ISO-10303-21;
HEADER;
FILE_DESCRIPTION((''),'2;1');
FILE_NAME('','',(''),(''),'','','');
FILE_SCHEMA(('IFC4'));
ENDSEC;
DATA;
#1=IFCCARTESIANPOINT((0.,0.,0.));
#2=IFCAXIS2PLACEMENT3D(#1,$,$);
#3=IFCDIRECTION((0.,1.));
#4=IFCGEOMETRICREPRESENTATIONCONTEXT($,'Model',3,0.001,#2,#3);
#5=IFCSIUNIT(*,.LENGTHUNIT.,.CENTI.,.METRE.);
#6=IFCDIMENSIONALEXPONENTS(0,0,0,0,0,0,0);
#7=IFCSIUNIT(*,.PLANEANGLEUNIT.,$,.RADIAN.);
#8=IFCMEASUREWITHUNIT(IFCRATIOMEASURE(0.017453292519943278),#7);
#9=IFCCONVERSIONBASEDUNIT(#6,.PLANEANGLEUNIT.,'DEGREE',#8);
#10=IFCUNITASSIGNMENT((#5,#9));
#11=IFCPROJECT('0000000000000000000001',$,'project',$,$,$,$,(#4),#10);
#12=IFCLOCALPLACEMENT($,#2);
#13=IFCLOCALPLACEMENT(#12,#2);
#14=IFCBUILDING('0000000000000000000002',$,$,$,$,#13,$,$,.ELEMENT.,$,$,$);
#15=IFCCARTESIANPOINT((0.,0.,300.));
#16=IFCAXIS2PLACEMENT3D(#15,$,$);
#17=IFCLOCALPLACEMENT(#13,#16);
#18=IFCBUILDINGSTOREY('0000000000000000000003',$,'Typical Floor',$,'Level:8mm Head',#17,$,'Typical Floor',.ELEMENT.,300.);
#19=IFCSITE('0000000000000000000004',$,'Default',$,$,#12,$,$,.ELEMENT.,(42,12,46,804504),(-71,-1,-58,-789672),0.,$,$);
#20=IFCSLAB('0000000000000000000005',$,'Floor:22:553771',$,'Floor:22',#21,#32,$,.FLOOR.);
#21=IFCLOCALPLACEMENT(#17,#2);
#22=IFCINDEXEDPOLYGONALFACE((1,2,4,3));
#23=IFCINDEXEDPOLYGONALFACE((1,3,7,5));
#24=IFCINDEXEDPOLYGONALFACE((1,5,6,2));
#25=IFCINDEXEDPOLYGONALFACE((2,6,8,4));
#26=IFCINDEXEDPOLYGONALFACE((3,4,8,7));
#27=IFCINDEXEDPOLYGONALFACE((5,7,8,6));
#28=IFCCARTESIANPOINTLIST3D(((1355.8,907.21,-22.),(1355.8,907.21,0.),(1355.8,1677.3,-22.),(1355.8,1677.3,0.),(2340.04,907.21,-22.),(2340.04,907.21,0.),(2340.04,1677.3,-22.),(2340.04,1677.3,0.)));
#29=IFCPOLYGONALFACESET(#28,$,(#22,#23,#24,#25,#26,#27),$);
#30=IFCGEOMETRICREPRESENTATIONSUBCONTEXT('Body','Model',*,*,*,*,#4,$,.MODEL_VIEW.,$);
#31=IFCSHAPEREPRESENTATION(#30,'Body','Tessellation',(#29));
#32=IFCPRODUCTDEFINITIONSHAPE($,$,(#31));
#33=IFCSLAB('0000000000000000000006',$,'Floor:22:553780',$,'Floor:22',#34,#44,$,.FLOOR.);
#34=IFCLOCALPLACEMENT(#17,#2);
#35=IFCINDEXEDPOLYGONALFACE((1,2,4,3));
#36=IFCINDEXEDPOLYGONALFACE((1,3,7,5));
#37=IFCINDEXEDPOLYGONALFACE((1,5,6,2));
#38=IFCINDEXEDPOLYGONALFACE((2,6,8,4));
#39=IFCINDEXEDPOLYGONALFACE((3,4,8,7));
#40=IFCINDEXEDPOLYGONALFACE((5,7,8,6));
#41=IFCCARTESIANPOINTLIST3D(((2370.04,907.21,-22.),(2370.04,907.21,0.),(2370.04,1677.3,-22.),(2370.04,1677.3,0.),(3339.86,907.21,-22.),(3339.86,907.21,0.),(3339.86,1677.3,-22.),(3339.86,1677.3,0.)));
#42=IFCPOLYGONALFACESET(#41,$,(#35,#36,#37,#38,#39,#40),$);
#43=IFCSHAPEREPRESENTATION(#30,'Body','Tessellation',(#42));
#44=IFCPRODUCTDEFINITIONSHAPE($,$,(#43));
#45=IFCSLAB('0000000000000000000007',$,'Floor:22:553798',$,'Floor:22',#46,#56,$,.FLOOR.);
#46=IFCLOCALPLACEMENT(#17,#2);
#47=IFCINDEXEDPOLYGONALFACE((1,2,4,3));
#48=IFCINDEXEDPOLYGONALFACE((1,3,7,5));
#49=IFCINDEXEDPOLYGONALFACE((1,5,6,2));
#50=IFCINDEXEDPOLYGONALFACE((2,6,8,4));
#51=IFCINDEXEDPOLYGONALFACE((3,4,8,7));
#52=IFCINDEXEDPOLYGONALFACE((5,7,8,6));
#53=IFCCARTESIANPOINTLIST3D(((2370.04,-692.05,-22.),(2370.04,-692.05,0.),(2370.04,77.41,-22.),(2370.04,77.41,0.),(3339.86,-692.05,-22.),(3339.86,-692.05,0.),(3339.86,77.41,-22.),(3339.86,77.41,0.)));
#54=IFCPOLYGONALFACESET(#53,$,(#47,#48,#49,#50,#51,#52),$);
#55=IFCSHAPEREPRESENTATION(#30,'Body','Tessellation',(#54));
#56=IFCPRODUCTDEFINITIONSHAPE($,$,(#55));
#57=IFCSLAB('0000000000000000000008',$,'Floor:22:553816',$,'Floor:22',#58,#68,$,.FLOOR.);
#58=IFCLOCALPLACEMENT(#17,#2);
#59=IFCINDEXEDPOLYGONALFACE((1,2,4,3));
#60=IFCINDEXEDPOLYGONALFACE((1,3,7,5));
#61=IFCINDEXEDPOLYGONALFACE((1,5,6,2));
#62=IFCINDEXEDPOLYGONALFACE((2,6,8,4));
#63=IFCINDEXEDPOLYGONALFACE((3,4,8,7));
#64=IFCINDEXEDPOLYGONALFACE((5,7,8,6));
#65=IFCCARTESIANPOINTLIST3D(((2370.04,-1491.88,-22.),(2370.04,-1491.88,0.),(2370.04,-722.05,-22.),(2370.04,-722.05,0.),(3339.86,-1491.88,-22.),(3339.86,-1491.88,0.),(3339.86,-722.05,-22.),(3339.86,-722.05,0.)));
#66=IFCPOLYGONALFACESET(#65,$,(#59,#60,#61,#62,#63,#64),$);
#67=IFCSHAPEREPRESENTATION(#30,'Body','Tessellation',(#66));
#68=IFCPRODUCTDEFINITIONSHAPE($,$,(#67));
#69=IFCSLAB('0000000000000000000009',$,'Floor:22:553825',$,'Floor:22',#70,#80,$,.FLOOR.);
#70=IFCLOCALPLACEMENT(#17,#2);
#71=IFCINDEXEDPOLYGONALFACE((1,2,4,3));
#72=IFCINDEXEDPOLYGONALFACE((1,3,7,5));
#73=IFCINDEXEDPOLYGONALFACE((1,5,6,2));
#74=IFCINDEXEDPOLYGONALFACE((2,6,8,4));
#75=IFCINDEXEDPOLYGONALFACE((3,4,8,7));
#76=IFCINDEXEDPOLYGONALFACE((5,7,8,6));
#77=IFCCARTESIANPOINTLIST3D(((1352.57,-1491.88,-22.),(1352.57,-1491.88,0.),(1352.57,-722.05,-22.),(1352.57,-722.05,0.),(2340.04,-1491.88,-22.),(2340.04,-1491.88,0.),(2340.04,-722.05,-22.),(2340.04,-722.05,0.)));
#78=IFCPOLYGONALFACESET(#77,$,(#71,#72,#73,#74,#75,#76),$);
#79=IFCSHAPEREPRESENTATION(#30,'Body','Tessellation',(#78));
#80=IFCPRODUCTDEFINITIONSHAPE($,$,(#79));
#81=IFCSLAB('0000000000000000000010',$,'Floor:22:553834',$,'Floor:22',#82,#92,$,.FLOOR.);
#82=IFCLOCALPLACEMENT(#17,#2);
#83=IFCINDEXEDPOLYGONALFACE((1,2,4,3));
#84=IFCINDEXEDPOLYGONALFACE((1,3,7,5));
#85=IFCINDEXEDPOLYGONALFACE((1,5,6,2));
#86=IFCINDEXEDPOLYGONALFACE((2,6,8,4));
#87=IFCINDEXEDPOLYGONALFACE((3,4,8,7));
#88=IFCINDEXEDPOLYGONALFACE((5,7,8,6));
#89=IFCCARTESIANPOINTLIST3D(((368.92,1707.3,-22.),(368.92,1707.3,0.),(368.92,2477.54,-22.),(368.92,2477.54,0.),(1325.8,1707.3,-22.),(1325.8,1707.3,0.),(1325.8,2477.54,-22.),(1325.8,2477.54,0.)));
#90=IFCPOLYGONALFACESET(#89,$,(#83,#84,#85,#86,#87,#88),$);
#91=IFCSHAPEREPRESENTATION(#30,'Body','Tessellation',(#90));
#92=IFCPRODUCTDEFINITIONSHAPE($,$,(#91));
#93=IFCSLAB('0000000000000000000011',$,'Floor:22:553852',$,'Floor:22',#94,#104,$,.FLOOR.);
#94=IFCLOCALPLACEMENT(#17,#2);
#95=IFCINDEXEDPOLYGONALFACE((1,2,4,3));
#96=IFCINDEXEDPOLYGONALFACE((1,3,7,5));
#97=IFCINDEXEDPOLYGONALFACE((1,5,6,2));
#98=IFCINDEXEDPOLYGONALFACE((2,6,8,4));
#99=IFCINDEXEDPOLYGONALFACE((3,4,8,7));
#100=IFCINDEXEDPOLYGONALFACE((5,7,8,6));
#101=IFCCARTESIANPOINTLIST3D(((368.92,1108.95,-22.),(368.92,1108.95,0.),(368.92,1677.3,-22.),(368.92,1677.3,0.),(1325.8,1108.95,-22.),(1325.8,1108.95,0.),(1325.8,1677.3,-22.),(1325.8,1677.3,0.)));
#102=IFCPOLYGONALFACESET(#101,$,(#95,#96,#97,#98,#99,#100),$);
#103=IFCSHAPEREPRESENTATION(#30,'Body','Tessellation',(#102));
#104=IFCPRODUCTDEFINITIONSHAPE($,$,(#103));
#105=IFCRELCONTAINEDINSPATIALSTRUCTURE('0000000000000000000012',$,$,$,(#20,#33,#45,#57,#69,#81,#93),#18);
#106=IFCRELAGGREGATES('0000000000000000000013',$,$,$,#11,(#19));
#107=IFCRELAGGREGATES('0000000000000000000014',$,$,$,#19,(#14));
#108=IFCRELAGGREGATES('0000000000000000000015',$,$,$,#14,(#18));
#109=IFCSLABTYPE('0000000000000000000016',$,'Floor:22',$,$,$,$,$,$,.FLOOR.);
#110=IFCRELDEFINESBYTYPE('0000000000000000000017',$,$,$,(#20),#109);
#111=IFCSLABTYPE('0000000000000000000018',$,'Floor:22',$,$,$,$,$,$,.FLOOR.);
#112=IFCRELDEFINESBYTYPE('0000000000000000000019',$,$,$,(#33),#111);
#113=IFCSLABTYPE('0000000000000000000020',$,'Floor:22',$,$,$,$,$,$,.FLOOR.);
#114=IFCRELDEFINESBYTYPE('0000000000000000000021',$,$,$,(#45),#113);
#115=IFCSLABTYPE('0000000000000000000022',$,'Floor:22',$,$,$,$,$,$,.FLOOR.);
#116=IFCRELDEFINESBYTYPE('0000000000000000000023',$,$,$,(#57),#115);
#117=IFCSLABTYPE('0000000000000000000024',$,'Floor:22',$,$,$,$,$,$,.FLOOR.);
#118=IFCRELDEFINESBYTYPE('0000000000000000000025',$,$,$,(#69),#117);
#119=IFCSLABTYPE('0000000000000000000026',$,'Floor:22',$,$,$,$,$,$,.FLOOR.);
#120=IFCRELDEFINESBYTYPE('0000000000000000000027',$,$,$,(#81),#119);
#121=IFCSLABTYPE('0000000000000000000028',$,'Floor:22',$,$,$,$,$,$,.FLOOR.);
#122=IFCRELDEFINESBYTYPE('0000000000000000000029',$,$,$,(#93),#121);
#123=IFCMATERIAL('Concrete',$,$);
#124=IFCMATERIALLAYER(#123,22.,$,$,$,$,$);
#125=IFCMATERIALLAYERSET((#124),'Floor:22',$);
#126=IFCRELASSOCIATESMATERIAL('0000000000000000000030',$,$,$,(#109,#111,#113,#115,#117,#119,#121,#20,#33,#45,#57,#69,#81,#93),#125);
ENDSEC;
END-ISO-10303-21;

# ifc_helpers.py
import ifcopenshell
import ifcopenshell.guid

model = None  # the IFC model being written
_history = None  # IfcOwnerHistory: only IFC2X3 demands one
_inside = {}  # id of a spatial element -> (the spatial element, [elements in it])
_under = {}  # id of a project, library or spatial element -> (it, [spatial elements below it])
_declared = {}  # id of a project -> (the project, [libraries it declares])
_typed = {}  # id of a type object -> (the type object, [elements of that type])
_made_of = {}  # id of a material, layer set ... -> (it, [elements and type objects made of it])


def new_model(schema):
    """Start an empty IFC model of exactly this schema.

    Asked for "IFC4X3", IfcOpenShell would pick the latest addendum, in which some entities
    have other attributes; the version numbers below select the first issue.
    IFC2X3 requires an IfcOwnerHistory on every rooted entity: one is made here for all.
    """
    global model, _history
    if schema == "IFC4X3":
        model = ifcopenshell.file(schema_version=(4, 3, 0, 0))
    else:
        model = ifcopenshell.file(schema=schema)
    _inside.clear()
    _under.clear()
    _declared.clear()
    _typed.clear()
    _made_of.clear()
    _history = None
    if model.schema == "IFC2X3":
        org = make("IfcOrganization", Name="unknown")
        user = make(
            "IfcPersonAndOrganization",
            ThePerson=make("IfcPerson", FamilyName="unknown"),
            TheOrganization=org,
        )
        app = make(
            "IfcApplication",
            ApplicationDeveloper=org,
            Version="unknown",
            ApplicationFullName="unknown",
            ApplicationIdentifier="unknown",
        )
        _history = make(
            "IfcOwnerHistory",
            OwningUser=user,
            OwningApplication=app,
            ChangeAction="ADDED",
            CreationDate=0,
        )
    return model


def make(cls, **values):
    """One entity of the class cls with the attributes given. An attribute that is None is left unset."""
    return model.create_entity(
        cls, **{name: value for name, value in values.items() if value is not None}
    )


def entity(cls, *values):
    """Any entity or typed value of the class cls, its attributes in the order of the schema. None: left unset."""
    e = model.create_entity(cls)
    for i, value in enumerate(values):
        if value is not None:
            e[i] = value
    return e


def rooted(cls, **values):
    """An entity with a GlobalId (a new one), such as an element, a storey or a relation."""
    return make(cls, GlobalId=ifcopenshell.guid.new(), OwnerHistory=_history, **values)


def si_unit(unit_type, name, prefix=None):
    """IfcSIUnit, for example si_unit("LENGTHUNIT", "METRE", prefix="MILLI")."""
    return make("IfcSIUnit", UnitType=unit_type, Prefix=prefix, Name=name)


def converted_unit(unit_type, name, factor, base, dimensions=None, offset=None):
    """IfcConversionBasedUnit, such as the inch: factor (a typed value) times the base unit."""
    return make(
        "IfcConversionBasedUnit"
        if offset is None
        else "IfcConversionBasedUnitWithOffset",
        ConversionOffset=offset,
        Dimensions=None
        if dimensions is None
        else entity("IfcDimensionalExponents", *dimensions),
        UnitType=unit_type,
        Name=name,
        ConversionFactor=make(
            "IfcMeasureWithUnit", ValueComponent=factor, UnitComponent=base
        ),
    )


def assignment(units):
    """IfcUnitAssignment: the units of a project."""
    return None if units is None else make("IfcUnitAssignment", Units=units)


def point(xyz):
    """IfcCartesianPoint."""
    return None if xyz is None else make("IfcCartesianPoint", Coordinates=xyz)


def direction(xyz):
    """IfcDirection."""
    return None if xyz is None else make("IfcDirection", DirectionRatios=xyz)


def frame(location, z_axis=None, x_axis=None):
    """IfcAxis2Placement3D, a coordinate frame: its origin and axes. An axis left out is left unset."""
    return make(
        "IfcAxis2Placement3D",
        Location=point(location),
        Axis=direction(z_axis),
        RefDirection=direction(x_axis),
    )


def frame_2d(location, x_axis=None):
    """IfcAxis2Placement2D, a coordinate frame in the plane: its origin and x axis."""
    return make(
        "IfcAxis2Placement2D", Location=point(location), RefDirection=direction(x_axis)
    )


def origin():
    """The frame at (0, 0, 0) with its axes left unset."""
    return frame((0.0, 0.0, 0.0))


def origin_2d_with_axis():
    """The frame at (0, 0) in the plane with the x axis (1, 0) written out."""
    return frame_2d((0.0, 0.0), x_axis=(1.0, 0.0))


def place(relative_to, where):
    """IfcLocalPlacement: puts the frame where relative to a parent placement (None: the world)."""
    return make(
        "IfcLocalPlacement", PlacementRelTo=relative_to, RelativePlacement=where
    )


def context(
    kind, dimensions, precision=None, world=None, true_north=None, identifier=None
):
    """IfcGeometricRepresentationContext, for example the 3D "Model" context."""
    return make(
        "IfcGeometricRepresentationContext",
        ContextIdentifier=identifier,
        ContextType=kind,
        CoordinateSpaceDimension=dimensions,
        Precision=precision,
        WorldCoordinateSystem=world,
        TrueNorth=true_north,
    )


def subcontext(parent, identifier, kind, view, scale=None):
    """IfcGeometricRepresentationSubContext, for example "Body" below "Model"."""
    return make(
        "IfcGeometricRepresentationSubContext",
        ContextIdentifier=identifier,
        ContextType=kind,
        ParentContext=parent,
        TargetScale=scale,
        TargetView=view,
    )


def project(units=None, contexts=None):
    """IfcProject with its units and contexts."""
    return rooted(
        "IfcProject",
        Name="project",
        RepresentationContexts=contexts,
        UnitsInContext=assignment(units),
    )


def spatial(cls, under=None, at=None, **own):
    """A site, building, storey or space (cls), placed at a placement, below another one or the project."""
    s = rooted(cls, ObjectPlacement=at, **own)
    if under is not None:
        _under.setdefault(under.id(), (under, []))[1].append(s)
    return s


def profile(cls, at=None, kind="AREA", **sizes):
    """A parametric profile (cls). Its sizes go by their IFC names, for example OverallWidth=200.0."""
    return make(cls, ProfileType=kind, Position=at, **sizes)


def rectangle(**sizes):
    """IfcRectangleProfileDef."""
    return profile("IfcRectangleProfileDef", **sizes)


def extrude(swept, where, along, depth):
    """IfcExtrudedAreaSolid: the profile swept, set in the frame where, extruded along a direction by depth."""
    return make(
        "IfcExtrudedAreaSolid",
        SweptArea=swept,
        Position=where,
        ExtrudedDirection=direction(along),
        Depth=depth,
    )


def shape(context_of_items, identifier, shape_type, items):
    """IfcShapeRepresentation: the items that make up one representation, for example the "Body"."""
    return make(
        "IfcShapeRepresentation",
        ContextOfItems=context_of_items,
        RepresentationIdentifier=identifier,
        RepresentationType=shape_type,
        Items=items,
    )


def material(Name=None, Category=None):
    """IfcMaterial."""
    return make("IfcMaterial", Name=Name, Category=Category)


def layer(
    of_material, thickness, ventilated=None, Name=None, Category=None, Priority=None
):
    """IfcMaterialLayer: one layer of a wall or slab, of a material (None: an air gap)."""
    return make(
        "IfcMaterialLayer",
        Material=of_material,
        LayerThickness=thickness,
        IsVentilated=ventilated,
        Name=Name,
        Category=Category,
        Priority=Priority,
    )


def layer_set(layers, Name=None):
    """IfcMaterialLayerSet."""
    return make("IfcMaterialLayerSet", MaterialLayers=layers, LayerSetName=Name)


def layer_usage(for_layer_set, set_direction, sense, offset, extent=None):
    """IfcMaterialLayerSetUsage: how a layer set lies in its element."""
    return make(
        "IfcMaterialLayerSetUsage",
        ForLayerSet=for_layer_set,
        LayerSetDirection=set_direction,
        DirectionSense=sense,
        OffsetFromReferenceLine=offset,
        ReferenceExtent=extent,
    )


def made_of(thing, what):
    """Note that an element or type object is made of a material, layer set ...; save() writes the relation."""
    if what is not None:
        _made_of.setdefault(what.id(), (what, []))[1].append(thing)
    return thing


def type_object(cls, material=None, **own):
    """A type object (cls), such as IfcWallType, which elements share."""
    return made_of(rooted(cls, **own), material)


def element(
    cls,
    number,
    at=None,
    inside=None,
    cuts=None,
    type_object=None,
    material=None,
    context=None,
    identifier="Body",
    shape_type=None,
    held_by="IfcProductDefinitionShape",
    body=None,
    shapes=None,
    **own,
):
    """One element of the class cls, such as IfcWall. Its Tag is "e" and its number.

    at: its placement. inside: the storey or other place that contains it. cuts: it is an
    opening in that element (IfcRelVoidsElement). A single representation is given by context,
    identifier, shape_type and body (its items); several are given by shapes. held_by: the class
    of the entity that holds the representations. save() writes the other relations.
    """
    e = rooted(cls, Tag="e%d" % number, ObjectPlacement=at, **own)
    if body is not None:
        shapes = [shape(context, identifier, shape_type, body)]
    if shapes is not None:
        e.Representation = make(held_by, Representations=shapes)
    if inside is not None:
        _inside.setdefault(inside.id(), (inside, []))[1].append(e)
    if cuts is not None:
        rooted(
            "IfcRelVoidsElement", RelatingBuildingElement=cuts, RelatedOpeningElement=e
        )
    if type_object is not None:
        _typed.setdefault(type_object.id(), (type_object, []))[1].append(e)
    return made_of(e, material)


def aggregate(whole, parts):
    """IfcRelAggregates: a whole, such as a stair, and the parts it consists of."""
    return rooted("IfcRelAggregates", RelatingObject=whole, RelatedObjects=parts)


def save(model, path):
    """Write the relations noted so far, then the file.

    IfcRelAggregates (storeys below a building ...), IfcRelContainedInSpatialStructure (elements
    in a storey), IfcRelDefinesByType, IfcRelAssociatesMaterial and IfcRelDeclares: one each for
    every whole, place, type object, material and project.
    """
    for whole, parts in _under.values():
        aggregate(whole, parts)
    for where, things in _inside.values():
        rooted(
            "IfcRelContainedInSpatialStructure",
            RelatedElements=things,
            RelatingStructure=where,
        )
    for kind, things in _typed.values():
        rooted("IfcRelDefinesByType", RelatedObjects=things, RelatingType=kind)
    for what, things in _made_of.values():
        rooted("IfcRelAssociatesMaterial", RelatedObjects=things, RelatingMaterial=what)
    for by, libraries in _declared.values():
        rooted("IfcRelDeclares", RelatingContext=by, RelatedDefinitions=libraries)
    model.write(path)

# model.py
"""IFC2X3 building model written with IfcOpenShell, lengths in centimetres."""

from ifc_helpers import new_model, entity, si_unit, converted_unit, direction, frame, frame_2d, origin, origin_2d_with_axis, place, context, subcontext, project, spatial, rectangle, extrude, material, layer, layer_set, layer_usage, type_object, element, save


model = new_model("IFC2X3")

# Units and contexts
model_context = context("Model", 3, precision=0.001, world=origin(), true_north=direction((0.0, 1.0)))
body_context = subcontext(model_context, "Body", "Model", "MODEL_VIEW")
ifc_project = project(units=[si_unit("LENGTHUNIT", "METRE", prefix="CENTI"), converted_unit("PLANEANGLEUNIT", "DEGREE", entity("IfcRatioMeasure", 0.017453292519943278), si_unit("PLANEANGLEUNIT", "RADIAN"), dimensions=[0, 0, 0, 0, 0, 0, 0])], contexts=[model_context])

# Site, building, storey
site_placement = place(None, origin())
site = spatial("IfcSite", under=ifc_project, at=site_placement, Name="Default", CompositionType="ELEMENT", RefLatitude=(42, 12, 46, 804504), RefLongitude=(-71, -1, -58, -789672), RefElevation=0.0)
building_placement = place(site_placement, origin())
building = spatial("IfcBuilding", under=site, at=building_placement, CompositionType="ELEMENT")
storey_placement = place(building_placement, frame((0.0, 0.0, 300.0)))
storey = spatial("IfcBuildingStorey", under=building, at=storey_placement, Name="Typical Floor", ObjectType="Level:8mm Head", LongName="Typical Floor", CompositionType="ELEMENT", Elevation=300.0)

# Shared definitions
ifc_material = material(Name="Concrete")

# Slabs
ifc_layer = layer(ifc_material, 22.0)
ifc_layer_set = layer_set([ifc_layer], Name="Floor:22")
ifc_layer_usage_1 = layer_usage(ifc_layer_set, "AXIS3", "POSITIVE", 0.0)
slab_type_1 = type_object("IfcSlabType", Name="Floor:22", PredefinedType="FLOOR", material=ifc_layer_set)
slab_1_placement = place(storey_placement, origin())
element("IfcSlab", 1, at=slab_1_placement, inside=storey, type_object=slab_type_1, material=ifc_layer_usage_1, Name="Floor:22:553771", ObjectType="Floor:22", PredefinedType="FLOOR", context=body_context, shape_type="SweptSolid", body=[
    extrude(rectangle(XDim=770.09, YDim=984.24, at=origin_2d_with_axis()), frame((1847.92, 1292.26, 0.0), z_axis=(0.0, 0.0, -1.0), x_axis=(0.0, 1.0, 0.0)), (0.0, 0.0, 1.0), 22.0),
])
ifc_layer_usage_2 = layer_usage(ifc_layer_set, "AXIS3", "POSITIVE", 0.0)
slab_type_2 = type_object("IfcSlabType", Name="Floor:22", PredefinedType="FLOOR", material=ifc_layer_set)
slab_2_placement = place(storey_placement, origin())
element("IfcSlab", 2, at=slab_2_placement, inside=storey, type_object=slab_type_2, material=ifc_layer_usage_2, Name="Floor:22:553780", ObjectType="Floor:22", PredefinedType="FLOOR", context=body_context, shape_type="SweptSolid", body=[
    extrude(rectangle(XDim=770.09, YDim=969.83, at=frame_2d((0.0, 0.0), x_axis=(1.0, 0.0))), frame((2854.95, 1292.26, 0.0), z_axis=(0.0, 0.0, -1.0), x_axis=(0.0, 1.0, 0.0)), (0.0, 0.0, 1.0), 22.0),
])
ifc_layer_usage_3 = layer_usage(ifc_layer_set, "AXIS3", "POSITIVE", 0.0)
slab_type_3 = type_object("IfcSlabType", Name="Floor:22", PredefinedType="FLOOR", material=ifc_layer_set)
slab_3_placement = place(storey_placement, origin())
element("IfcSlab", 3, at=slab_3_placement, inside=storey, type_object=slab_type_3, material=ifc_layer_usage_3, Name="Floor:22:553798", ObjectType="Floor:22", PredefinedType="FLOOR", context=body_context, shape_type="SweptSolid", body=[
    extrude(rectangle(XDim=769.46, YDim=969.83, at=frame_2d((0.0, 0.0), x_axis=(1.0, 0.0))), frame((2854.95, -307.32, 0.0), z_axis=(0.0, 0.0, -1.0), x_axis=(0.0, 1.0, 0.0)), (0.0, 0.0, 1.0), 22.0),
])
ifc_layer_usage_4 = layer_usage(ifc_layer_set, "AXIS3", "POSITIVE", 0.0)
slab_type_4 = type_object("IfcSlabType", Name="Floor:22", PredefinedType="FLOOR", material=ifc_layer_set)
slab_4_placement = place(storey_placement, origin())
element("IfcSlab", 4, at=slab_4_placement, inside=storey, type_object=slab_type_4, material=ifc_layer_usage_4, Name="Floor:22:553816", ObjectType="Floor:22", PredefinedType="FLOOR", context=body_context, shape_type="SweptSolid", body=[
    extrude(rectangle(XDim=769.83, YDim=969.83, at=frame_2d((0.0, 0.0), x_axis=(1.0, 0.0))), frame((2854.95, -1106.96, 0.0), z_axis=(0.0, 0.0, -1.0), x_axis=(0.0, 1.0, 0.0)), (0.0, 0.0, 1.0), 22.0),
])
ifc_layer_usage_5 = layer_usage(ifc_layer_set, "AXIS3", "POSITIVE", 0.0)
slab_type_5 = type_object("IfcSlabType", Name="Floor:22", PredefinedType="FLOOR", material=ifc_layer_set)
slab_5_placement = place(storey_placement, origin())
element("IfcSlab", 5, at=slab_5_placement, inside=storey, type_object=slab_type_5, material=ifc_layer_usage_5, Name="Floor:22:553825", ObjectType="Floor:22", PredefinedType="FLOOR", context=body_context, shape_type="SweptSolid", body=[
    extrude(rectangle(XDim=769.83, YDim=987.46, at=frame_2d((0.0, 0.0), x_axis=(1.0, 0.0))), frame((1846.3, -1106.96, 0.0), z_axis=(0.0, 0.0, -1.0), x_axis=(0.0, 1.0, 0.0)), (0.0, 0.0, 1.0), 22.0),
])
ifc_layer_usage_6 = layer_usage(ifc_layer_set, "AXIS3", "POSITIVE", 0.0)
slab_type_6 = type_object("IfcSlabType", Name="Floor:22", PredefinedType="FLOOR", material=ifc_layer_set)
slab_6_placement = place(storey_placement, origin())
element("IfcSlab", 6, at=slab_6_placement, inside=storey, type_object=slab_type_6, material=ifc_layer_usage_6, Name="Floor:22:553834", ObjectType="Floor:22", PredefinedType="FLOOR", context=body_context, shape_type="SweptSolid", body=[
    extrude(rectangle(XDim=770.24, YDim=956.88, at=frame_2d((0.0, 0.0), x_axis=(1.0, 0.0))), frame((847.36, 2092.42, 0.0), z_axis=(0.0, 0.0, -1.0), x_axis=(0.0, 1.0, 0.0)), (0.0, 0.0, 1.0), 22.0),
])
ifc_layer_usage_7 = layer_usage(ifc_layer_set, "AXIS3", "POSITIVE", 0.0)
slab_type_7 = type_object("IfcSlabType", Name="Floor:22", PredefinedType="FLOOR", material=ifc_layer_set)
slab_7_placement = place(storey_placement, origin())
element("IfcSlab", 7, at=slab_7_placement, inside=storey, type_object=slab_type_7, material=ifc_layer_usage_7, Name="Floor:22:553852", ObjectType="Floor:22", PredefinedType="FLOOR", context=body_context, shape_type="SweptSolid", body=[
    extrude(rectangle(XDim=568.35, YDim=956.88, at=origin_2d_with_axis()), frame((847.36, 1393.13, 0.0), z_axis=(0.0, 0.0, -1.0), x_axis=(0.0, 1.0, 0.0)), (0.0, 0.0, 1.0), 22.0),
])

save(model, "model.ifc")
